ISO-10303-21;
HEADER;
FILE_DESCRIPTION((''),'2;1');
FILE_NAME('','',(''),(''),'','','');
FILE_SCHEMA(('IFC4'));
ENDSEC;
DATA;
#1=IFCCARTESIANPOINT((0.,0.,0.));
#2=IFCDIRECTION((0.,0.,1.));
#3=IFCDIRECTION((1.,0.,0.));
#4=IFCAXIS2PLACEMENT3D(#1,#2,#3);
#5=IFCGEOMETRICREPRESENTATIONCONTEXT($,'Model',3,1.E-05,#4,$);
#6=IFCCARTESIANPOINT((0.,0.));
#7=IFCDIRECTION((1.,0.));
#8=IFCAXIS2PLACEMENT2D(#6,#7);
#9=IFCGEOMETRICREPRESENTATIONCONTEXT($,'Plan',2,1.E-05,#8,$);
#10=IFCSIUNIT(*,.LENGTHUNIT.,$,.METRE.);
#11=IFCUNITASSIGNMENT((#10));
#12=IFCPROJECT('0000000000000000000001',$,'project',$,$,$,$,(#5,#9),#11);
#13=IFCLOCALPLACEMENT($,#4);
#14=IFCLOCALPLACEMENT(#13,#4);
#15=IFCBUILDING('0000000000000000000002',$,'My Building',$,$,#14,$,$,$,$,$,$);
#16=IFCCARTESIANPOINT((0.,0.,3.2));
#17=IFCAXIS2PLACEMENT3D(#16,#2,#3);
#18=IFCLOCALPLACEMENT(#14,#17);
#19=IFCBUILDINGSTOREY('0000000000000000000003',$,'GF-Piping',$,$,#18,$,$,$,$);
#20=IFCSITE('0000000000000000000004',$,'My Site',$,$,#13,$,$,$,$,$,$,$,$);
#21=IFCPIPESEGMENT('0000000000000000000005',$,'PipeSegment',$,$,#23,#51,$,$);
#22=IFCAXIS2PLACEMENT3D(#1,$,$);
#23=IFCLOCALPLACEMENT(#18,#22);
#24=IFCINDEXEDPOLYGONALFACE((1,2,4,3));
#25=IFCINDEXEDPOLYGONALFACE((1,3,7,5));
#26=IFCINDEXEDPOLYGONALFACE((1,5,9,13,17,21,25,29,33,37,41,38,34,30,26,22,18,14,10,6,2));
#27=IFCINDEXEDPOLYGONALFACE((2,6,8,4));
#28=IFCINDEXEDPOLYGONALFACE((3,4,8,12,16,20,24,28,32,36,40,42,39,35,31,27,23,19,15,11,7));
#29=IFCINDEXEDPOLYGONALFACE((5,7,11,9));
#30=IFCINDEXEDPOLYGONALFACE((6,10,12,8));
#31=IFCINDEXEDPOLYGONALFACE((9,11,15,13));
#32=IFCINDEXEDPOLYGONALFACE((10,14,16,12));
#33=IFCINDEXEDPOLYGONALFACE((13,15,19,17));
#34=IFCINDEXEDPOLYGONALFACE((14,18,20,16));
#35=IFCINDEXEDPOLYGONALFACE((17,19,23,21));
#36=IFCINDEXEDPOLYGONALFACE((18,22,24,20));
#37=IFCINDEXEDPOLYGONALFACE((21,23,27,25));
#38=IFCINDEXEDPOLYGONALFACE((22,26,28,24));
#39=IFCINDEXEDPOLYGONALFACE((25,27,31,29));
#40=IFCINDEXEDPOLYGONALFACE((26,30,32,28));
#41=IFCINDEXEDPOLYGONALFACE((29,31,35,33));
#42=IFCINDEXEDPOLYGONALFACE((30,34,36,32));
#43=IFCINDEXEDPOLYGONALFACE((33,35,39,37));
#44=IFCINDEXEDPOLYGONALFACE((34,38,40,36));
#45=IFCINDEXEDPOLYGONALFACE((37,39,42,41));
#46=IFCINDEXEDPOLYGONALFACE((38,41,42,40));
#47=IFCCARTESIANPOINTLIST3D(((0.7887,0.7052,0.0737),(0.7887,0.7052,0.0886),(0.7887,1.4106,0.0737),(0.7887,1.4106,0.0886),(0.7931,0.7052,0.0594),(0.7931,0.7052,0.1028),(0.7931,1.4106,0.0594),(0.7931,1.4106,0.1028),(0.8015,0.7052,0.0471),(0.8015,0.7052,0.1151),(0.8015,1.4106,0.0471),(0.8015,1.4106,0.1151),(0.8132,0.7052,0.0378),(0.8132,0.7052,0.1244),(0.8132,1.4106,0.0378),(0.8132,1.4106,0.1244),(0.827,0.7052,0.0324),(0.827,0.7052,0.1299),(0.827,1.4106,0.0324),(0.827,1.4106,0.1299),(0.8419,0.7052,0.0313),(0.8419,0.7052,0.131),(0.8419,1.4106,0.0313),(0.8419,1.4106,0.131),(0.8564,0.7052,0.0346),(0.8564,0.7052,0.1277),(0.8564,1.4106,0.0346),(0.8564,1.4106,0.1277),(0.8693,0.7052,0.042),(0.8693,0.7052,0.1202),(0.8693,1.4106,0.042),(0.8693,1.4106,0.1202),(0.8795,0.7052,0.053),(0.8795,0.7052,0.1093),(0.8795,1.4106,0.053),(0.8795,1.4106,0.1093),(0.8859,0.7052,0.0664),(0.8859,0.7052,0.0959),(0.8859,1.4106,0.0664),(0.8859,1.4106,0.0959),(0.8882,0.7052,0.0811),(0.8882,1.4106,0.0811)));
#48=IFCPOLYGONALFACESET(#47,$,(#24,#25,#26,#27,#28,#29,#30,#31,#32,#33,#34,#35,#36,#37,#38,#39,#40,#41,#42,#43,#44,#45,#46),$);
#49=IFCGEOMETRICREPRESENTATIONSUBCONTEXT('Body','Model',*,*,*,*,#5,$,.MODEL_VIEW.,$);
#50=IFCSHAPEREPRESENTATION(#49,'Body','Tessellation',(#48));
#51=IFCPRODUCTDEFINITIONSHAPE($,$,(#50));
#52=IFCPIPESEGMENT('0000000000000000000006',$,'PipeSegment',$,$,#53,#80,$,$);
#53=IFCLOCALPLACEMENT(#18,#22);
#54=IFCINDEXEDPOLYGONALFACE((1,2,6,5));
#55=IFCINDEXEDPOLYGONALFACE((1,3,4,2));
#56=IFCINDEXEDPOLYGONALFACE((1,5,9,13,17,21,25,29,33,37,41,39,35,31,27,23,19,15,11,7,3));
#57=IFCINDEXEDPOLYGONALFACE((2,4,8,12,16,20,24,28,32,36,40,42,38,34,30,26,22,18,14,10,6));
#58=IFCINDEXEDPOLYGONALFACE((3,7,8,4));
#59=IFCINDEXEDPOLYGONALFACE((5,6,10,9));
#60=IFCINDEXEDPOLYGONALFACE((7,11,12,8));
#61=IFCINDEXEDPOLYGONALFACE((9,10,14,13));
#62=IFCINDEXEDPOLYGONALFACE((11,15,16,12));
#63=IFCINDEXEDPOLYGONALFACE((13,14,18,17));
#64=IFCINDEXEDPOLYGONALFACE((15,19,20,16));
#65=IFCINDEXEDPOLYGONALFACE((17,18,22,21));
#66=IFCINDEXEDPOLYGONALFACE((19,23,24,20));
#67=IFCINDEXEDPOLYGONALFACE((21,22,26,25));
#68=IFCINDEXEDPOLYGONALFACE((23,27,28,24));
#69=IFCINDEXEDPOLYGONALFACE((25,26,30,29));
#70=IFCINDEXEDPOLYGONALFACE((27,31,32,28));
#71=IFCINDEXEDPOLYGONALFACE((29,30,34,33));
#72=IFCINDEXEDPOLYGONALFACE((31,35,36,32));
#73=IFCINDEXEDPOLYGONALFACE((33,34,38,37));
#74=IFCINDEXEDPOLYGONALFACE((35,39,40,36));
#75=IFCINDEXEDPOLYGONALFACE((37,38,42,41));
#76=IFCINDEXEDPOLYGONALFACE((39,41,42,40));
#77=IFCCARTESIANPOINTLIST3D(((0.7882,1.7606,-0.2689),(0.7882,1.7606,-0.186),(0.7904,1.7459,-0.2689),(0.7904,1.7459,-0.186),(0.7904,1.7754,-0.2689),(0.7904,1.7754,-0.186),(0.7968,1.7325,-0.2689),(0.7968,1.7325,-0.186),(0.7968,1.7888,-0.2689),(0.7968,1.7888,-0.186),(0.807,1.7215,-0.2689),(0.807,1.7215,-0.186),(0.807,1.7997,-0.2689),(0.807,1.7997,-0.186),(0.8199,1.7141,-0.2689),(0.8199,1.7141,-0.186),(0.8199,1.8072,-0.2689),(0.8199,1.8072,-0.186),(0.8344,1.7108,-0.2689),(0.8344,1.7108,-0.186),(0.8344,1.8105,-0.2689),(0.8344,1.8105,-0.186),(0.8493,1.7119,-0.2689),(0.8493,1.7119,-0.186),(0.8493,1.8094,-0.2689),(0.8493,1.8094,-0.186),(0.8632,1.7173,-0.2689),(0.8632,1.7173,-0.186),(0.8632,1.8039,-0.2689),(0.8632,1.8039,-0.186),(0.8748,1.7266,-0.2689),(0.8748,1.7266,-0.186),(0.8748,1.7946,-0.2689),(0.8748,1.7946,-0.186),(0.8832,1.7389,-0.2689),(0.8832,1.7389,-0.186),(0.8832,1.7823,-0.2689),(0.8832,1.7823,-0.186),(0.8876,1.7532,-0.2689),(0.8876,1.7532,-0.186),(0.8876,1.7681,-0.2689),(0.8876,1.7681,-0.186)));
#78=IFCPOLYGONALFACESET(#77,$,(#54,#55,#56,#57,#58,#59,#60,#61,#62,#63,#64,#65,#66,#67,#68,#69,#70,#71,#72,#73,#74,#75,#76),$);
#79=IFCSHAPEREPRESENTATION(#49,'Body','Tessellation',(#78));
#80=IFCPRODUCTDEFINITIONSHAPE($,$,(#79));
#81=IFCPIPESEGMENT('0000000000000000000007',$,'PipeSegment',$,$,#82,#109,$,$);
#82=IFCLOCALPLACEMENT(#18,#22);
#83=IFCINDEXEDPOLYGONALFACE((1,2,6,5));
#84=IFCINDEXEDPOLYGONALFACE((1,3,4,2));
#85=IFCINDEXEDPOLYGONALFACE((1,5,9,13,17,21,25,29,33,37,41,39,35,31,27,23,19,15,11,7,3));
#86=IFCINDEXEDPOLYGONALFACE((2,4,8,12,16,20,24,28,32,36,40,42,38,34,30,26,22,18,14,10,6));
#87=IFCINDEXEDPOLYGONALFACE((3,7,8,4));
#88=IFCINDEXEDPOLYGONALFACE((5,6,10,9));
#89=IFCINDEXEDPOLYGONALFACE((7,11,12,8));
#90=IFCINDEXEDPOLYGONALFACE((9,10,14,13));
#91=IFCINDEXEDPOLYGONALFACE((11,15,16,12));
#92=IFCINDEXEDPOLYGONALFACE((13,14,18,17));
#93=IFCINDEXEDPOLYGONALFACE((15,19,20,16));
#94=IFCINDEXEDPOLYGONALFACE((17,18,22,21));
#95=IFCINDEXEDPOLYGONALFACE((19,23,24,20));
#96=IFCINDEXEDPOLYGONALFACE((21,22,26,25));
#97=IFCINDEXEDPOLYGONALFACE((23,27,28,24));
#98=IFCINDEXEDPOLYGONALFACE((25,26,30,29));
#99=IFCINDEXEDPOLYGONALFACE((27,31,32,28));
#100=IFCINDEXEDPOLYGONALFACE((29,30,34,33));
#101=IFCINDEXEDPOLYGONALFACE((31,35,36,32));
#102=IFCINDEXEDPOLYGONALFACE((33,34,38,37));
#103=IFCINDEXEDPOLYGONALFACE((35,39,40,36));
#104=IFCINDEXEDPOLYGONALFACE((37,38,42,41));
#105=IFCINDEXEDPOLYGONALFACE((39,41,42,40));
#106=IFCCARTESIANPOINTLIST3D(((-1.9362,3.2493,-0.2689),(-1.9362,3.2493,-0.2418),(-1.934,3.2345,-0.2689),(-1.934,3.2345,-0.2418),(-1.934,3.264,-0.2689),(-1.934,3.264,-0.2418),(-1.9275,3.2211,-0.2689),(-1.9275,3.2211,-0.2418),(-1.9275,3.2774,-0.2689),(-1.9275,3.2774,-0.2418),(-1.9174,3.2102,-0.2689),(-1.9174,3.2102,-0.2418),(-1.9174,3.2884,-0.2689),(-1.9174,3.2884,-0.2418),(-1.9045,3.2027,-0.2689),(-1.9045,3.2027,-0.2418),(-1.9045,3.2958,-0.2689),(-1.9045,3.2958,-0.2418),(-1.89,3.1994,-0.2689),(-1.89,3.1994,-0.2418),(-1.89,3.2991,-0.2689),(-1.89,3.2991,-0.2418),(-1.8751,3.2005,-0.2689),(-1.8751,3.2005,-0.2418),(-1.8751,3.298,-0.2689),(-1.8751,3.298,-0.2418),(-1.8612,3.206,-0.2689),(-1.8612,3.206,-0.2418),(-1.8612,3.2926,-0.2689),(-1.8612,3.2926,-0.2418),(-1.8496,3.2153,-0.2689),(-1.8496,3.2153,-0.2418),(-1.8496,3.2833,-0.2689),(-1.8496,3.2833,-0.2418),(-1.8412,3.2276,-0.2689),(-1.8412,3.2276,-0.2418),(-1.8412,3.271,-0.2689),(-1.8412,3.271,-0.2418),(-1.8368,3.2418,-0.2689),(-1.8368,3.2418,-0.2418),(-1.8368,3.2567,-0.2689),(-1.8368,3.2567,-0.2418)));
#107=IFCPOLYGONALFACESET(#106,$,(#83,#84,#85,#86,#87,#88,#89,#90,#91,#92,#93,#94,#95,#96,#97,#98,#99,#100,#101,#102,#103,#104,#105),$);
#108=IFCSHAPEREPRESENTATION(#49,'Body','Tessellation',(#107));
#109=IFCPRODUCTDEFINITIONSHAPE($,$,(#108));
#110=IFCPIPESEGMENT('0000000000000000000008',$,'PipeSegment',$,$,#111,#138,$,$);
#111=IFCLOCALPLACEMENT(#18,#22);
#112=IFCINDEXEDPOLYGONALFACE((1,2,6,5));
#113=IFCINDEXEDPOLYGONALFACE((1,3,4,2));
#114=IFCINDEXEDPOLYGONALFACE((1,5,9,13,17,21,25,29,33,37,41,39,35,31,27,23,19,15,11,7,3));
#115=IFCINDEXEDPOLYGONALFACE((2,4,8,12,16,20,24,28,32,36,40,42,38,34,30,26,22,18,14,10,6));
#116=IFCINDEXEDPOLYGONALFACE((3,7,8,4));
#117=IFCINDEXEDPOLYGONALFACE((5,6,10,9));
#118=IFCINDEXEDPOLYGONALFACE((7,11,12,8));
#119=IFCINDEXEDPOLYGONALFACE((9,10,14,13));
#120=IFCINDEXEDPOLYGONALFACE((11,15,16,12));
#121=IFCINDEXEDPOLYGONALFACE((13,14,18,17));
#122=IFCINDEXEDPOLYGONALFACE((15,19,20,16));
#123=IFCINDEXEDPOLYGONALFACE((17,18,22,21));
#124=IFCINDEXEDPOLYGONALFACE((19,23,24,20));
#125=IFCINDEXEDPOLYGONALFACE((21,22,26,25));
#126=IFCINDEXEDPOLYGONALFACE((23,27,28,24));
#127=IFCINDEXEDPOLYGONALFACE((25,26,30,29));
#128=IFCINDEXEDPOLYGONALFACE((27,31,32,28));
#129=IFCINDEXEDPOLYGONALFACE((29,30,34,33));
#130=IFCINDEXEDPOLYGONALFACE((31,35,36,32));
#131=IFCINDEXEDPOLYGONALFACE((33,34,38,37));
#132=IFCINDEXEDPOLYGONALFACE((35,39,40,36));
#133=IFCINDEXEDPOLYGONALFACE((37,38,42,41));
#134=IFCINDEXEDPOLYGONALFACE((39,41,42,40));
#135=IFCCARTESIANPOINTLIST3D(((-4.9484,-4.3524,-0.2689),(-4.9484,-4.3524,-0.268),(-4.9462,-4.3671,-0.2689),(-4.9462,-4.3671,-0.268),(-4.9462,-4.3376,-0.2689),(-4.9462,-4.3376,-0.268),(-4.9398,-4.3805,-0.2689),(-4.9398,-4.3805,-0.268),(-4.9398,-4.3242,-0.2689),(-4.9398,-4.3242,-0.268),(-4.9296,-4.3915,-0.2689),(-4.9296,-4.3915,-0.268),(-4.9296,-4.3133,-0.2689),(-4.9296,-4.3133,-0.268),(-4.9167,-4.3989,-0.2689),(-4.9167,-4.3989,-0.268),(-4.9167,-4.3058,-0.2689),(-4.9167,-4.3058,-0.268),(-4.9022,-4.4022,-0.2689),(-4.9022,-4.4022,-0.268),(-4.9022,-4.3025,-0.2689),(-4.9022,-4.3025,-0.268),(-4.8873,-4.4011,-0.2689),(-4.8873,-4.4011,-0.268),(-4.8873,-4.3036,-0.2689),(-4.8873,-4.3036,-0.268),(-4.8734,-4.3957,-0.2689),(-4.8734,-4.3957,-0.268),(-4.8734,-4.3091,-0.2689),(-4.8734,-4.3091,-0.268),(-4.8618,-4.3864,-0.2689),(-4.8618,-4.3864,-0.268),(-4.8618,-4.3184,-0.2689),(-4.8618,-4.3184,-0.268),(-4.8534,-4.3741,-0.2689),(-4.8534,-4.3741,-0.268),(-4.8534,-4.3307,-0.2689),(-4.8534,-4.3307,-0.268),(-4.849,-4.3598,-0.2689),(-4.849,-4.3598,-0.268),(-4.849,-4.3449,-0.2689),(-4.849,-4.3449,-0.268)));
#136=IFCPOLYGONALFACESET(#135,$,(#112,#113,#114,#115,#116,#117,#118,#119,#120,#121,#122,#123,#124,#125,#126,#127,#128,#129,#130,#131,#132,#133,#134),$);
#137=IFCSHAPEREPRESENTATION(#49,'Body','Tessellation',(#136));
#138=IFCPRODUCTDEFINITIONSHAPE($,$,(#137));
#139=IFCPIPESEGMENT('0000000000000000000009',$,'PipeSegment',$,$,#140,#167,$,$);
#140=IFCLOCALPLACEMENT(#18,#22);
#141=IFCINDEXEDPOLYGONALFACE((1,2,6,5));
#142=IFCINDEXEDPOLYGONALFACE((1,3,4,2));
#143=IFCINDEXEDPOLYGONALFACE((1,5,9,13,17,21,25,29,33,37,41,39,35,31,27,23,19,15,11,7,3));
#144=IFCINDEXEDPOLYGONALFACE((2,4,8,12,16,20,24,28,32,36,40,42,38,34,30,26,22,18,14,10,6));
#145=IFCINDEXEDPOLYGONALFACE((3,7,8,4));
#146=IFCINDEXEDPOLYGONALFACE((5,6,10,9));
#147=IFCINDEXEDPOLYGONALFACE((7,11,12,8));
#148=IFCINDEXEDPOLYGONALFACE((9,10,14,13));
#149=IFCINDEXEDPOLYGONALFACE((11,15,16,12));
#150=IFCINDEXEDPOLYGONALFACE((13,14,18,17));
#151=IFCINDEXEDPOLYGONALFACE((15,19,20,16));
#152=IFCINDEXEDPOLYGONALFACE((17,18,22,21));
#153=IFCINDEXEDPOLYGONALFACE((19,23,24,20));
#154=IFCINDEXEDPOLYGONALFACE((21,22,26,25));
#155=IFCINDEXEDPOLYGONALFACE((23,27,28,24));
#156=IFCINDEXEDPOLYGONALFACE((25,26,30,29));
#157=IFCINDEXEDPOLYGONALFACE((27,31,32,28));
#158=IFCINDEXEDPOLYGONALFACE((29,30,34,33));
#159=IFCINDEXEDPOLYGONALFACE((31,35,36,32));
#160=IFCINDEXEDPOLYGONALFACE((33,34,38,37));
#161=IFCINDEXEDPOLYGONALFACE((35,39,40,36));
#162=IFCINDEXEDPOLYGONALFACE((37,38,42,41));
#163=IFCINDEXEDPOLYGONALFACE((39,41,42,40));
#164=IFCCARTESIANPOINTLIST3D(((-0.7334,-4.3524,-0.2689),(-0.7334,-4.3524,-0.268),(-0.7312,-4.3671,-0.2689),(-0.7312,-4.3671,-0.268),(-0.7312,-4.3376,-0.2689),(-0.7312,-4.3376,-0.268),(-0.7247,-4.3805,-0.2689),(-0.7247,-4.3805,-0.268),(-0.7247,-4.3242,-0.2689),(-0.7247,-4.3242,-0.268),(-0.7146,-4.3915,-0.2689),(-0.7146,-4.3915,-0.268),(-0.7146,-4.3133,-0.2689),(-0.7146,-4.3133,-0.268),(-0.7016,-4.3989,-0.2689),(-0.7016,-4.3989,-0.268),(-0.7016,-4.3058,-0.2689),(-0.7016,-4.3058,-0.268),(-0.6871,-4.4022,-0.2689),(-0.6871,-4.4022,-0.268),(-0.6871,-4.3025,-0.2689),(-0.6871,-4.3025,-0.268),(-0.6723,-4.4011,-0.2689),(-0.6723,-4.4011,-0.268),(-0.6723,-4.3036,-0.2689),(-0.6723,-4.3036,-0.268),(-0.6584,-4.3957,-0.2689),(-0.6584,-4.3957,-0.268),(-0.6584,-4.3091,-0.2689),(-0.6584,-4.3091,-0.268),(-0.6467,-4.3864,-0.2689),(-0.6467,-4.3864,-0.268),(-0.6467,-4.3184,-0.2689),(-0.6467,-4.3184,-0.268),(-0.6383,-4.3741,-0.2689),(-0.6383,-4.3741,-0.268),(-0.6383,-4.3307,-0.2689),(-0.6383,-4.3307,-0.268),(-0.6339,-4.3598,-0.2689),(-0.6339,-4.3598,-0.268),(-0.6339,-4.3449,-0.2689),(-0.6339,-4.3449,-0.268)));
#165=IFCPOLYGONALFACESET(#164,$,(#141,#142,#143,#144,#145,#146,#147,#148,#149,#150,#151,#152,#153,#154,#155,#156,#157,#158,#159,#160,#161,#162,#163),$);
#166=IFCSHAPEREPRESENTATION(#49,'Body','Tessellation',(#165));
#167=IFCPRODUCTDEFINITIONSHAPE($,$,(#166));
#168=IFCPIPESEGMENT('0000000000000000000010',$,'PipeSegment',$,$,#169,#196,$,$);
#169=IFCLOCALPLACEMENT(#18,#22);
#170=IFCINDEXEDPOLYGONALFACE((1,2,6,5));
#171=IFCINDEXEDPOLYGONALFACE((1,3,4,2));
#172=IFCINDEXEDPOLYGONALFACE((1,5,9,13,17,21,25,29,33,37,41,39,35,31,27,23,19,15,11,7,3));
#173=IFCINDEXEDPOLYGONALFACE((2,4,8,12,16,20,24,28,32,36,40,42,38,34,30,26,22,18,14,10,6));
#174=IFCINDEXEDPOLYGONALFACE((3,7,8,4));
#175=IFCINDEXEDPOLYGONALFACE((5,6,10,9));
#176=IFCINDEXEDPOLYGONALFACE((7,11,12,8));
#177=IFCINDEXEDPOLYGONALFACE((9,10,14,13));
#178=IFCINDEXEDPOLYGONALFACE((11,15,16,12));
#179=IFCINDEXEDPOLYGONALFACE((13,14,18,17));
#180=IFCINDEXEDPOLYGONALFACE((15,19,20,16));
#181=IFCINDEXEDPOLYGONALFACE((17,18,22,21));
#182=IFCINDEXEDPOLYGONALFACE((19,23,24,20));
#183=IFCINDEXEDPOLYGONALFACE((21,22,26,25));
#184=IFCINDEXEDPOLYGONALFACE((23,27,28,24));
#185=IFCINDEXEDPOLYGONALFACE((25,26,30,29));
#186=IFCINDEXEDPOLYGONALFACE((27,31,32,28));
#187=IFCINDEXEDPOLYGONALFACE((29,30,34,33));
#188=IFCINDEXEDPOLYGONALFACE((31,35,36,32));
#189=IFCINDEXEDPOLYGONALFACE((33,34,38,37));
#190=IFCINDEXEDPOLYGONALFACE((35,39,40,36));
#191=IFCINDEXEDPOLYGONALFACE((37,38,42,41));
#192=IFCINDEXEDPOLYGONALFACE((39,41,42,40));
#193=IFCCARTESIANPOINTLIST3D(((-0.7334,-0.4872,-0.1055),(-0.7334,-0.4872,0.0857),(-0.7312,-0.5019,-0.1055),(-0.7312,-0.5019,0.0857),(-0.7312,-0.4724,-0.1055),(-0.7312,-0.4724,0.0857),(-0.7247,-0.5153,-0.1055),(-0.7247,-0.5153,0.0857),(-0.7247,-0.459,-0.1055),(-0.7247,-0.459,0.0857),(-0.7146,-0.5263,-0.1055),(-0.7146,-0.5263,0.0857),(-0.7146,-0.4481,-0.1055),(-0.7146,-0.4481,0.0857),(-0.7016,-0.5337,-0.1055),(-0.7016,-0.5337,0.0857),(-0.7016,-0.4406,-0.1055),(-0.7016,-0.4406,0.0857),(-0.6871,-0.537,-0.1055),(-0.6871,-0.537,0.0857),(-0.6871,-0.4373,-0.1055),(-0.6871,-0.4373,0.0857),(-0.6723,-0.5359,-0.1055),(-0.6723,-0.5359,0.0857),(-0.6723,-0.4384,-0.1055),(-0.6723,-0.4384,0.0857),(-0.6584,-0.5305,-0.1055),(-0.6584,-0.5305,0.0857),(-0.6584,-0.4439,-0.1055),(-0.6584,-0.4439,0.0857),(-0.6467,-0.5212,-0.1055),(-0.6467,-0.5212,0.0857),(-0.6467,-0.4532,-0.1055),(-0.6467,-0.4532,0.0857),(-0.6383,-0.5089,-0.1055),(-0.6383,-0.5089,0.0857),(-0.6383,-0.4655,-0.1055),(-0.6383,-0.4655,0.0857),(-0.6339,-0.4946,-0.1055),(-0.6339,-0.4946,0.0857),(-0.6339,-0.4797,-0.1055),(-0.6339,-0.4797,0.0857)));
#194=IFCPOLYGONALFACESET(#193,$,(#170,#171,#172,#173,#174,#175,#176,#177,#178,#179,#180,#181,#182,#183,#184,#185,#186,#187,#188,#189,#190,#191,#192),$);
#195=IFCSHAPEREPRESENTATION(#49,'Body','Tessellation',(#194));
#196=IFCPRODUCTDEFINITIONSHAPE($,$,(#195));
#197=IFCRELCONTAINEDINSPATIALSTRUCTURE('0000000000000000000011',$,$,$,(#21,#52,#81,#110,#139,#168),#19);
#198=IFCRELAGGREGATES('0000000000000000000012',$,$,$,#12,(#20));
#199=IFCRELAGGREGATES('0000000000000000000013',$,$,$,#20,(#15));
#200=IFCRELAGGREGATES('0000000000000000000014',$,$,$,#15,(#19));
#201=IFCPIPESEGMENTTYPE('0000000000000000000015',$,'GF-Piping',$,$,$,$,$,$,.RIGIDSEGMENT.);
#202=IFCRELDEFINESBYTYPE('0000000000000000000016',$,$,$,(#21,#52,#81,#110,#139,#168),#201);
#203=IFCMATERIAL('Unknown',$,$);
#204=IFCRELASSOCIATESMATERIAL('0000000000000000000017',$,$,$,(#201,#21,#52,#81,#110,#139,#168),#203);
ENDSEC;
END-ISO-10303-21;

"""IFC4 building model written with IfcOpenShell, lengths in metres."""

from ifc_helpers import new_model, si_unit, frame, origin_with_axes, origin_2d_with_axis, place, context, subcontext, project, spatial, circle, extrude, material, material_profile, profile_set, profile_usage, type_object, element, save


model = new_model("IFC4")

# Units and contexts
model_context = context("Model", 3, precision=1e-05, world=origin_with_axes())
plan_context = context("Plan", 2, precision=1e-05, world=origin_2d_with_axis())
body_context = subcontext(model_context, "Body", "Model", "MODEL_VIEW")
ifc_project = project(units=[si_unit("LENGTHUNIT", "METRE")], contexts=[model_context, plan_context])

# Site, building, storey
site_placement = place(None, origin_with_axes())
site = spatial("IfcSite", under=ifc_project, at=site_placement, Name="My Site")
building_placement = place(site_placement, origin_with_axes())
building = spatial("IfcBuilding", under=site, at=building_placement, Name="My Building")
storey_placement = place(building_placement, frame((0.0, 0.0, 3.2), z_axis=(0.0, 0.0, 1.0), x_axis=(1.0, 0.0, 0.0)))
storey = spatial("IfcBuildingStorey", under=building, at=storey_placement, Name="GF-Piping")

# Pipe segments
ifc_material = material(Name="Unknown")
ifc_material_profile = material_profile(ifc_material, circle(Radius=0.05))
ifc_profile_set = profile_set([ifc_material_profile])
pipe_segment_type = type_object("IfcPipeSegmentType", Name="GF-Piping", PredefinedType="RIGIDSEGMENT", material=ifc_profile_set)
ifc_profile_usage_1 = profile_usage(ifc_profile_set, cardinal=5)
pipe_segment_1_placement = place(storey_placement, frame((0.8382, 1.4106, 0.0811), z_axis=(0.0, -1.0, 0.0), x_axis=(1.0, 0.0, 0.0)))
element("IfcPipeSegment", 1, at=pipe_segment_1_placement, inside=storey, type_object=pipe_segment_type, material=ifc_profile_usage_1, Name="PipeSegment", context=body_context, shape_type="SweptSolid", body=[
    extrude(circle(Radius=0.05), origin_with_axes(), (0.0, 0.0, 1.0), 0.7054),
])
ifc_profile_usage_2 = profile_usage(ifc_profile_set, cardinal=5)
pipe_segment_2_placement = place(storey_placement, frame((0.8382, 1.7606, -0.186), z_axis=(0.0, 0.0, -1.0), x_axis=(-1.0, 0.0, 0.0)))
element("IfcPipeSegment", 2, at=pipe_segment_2_placement, inside=storey, type_object=pipe_segment_type, material=ifc_profile_usage_2, Name="PipeSegment", context=body_context, shape_type="SweptSolid", body=[
    extrude(circle(Radius=0.05), origin_with_axes(), (0.0, 0.0, 1.0), 0.0828),
])
ifc_profile_usage_3 = profile_usage(ifc_profile_set, cardinal=5)
pipe_segment_3_placement = place(storey_placement, frame((-1.8862, 3.2493, -0.2418), z_axis=(0.0, 0.0, -1.0), x_axis=(-1.0, 0.0, 0.0)))
element("IfcPipeSegment", 3, at=pipe_segment_3_placement, inside=storey, type_object=pipe_segment_type, material=ifc_profile_usage_3, Name="PipeSegment", context=body_context, shape_type="SweptSolid", body=[
    extrude(circle(Radius=0.05), origin_with_axes(), (0.0, 0.0, 1.0), 0.0271),
])
ifc_profile_usage_4 = profile_usage(ifc_profile_set, cardinal=5)
pipe_segment_4_placement = place(storey_placement, frame((-4.8984, -4.3524, -0.268), z_axis=(0.0, 0.0, -1.0), x_axis=(-1.0, 0.0, 0.0)))
element("IfcPipeSegment", 4, at=pipe_segment_4_placement, inside=storey, type_object=pipe_segment_type, material=ifc_profile_usage_4, Name="PipeSegment", context=body_context, shape_type="SweptSolid", body=[
    extrude(circle(Radius=0.05), origin_with_axes(), (0.0, 0.0, 1.0), 0.0009),
])
ifc_profile_usage_5 = profile_usage(ifc_profile_set, cardinal=5)
pipe_segment_5_placement = place(storey_placement, frame((-0.6834, -4.3524, -0.268), z_axis=(0.0, 0.0, -1.0), x_axis=(-1.0, 0.0, 0.0)))
element("IfcPipeSegment", 5, at=pipe_segment_5_placement, inside=storey, type_object=pipe_segment_type, material=ifc_profile_usage_5, Name="PipeSegment", context=body_context, shape_type="SweptSolid", body=[
    extrude(circle(Radius=0.05), origin_with_axes(), (0.0, 0.0, 1.0), 0.0009),
])
ifc_profile_usage_6 = profile_usage(ifc_profile_set, cardinal=5)
pipe_segment_6_placement = place(storey_placement, frame((-0.6834, -0.4872, 0.0857), z_axis=(0.0, 0.0, -1.0), x_axis=(-1.0, 0.0, 0.0)))
element("IfcPipeSegment", 6, at=pipe_segment_6_placement, inside=storey, type_object=pipe_segment_type, material=ifc_profile_usage_6, Name="PipeSegment", context=body_context, shape_type="SweptSolid", body=[
    extrude(circle(Radius=0.05), origin_with_axes(), (0.0, 0.0, 1.0), 0.1912),
])

save(model, "model.ifc")
